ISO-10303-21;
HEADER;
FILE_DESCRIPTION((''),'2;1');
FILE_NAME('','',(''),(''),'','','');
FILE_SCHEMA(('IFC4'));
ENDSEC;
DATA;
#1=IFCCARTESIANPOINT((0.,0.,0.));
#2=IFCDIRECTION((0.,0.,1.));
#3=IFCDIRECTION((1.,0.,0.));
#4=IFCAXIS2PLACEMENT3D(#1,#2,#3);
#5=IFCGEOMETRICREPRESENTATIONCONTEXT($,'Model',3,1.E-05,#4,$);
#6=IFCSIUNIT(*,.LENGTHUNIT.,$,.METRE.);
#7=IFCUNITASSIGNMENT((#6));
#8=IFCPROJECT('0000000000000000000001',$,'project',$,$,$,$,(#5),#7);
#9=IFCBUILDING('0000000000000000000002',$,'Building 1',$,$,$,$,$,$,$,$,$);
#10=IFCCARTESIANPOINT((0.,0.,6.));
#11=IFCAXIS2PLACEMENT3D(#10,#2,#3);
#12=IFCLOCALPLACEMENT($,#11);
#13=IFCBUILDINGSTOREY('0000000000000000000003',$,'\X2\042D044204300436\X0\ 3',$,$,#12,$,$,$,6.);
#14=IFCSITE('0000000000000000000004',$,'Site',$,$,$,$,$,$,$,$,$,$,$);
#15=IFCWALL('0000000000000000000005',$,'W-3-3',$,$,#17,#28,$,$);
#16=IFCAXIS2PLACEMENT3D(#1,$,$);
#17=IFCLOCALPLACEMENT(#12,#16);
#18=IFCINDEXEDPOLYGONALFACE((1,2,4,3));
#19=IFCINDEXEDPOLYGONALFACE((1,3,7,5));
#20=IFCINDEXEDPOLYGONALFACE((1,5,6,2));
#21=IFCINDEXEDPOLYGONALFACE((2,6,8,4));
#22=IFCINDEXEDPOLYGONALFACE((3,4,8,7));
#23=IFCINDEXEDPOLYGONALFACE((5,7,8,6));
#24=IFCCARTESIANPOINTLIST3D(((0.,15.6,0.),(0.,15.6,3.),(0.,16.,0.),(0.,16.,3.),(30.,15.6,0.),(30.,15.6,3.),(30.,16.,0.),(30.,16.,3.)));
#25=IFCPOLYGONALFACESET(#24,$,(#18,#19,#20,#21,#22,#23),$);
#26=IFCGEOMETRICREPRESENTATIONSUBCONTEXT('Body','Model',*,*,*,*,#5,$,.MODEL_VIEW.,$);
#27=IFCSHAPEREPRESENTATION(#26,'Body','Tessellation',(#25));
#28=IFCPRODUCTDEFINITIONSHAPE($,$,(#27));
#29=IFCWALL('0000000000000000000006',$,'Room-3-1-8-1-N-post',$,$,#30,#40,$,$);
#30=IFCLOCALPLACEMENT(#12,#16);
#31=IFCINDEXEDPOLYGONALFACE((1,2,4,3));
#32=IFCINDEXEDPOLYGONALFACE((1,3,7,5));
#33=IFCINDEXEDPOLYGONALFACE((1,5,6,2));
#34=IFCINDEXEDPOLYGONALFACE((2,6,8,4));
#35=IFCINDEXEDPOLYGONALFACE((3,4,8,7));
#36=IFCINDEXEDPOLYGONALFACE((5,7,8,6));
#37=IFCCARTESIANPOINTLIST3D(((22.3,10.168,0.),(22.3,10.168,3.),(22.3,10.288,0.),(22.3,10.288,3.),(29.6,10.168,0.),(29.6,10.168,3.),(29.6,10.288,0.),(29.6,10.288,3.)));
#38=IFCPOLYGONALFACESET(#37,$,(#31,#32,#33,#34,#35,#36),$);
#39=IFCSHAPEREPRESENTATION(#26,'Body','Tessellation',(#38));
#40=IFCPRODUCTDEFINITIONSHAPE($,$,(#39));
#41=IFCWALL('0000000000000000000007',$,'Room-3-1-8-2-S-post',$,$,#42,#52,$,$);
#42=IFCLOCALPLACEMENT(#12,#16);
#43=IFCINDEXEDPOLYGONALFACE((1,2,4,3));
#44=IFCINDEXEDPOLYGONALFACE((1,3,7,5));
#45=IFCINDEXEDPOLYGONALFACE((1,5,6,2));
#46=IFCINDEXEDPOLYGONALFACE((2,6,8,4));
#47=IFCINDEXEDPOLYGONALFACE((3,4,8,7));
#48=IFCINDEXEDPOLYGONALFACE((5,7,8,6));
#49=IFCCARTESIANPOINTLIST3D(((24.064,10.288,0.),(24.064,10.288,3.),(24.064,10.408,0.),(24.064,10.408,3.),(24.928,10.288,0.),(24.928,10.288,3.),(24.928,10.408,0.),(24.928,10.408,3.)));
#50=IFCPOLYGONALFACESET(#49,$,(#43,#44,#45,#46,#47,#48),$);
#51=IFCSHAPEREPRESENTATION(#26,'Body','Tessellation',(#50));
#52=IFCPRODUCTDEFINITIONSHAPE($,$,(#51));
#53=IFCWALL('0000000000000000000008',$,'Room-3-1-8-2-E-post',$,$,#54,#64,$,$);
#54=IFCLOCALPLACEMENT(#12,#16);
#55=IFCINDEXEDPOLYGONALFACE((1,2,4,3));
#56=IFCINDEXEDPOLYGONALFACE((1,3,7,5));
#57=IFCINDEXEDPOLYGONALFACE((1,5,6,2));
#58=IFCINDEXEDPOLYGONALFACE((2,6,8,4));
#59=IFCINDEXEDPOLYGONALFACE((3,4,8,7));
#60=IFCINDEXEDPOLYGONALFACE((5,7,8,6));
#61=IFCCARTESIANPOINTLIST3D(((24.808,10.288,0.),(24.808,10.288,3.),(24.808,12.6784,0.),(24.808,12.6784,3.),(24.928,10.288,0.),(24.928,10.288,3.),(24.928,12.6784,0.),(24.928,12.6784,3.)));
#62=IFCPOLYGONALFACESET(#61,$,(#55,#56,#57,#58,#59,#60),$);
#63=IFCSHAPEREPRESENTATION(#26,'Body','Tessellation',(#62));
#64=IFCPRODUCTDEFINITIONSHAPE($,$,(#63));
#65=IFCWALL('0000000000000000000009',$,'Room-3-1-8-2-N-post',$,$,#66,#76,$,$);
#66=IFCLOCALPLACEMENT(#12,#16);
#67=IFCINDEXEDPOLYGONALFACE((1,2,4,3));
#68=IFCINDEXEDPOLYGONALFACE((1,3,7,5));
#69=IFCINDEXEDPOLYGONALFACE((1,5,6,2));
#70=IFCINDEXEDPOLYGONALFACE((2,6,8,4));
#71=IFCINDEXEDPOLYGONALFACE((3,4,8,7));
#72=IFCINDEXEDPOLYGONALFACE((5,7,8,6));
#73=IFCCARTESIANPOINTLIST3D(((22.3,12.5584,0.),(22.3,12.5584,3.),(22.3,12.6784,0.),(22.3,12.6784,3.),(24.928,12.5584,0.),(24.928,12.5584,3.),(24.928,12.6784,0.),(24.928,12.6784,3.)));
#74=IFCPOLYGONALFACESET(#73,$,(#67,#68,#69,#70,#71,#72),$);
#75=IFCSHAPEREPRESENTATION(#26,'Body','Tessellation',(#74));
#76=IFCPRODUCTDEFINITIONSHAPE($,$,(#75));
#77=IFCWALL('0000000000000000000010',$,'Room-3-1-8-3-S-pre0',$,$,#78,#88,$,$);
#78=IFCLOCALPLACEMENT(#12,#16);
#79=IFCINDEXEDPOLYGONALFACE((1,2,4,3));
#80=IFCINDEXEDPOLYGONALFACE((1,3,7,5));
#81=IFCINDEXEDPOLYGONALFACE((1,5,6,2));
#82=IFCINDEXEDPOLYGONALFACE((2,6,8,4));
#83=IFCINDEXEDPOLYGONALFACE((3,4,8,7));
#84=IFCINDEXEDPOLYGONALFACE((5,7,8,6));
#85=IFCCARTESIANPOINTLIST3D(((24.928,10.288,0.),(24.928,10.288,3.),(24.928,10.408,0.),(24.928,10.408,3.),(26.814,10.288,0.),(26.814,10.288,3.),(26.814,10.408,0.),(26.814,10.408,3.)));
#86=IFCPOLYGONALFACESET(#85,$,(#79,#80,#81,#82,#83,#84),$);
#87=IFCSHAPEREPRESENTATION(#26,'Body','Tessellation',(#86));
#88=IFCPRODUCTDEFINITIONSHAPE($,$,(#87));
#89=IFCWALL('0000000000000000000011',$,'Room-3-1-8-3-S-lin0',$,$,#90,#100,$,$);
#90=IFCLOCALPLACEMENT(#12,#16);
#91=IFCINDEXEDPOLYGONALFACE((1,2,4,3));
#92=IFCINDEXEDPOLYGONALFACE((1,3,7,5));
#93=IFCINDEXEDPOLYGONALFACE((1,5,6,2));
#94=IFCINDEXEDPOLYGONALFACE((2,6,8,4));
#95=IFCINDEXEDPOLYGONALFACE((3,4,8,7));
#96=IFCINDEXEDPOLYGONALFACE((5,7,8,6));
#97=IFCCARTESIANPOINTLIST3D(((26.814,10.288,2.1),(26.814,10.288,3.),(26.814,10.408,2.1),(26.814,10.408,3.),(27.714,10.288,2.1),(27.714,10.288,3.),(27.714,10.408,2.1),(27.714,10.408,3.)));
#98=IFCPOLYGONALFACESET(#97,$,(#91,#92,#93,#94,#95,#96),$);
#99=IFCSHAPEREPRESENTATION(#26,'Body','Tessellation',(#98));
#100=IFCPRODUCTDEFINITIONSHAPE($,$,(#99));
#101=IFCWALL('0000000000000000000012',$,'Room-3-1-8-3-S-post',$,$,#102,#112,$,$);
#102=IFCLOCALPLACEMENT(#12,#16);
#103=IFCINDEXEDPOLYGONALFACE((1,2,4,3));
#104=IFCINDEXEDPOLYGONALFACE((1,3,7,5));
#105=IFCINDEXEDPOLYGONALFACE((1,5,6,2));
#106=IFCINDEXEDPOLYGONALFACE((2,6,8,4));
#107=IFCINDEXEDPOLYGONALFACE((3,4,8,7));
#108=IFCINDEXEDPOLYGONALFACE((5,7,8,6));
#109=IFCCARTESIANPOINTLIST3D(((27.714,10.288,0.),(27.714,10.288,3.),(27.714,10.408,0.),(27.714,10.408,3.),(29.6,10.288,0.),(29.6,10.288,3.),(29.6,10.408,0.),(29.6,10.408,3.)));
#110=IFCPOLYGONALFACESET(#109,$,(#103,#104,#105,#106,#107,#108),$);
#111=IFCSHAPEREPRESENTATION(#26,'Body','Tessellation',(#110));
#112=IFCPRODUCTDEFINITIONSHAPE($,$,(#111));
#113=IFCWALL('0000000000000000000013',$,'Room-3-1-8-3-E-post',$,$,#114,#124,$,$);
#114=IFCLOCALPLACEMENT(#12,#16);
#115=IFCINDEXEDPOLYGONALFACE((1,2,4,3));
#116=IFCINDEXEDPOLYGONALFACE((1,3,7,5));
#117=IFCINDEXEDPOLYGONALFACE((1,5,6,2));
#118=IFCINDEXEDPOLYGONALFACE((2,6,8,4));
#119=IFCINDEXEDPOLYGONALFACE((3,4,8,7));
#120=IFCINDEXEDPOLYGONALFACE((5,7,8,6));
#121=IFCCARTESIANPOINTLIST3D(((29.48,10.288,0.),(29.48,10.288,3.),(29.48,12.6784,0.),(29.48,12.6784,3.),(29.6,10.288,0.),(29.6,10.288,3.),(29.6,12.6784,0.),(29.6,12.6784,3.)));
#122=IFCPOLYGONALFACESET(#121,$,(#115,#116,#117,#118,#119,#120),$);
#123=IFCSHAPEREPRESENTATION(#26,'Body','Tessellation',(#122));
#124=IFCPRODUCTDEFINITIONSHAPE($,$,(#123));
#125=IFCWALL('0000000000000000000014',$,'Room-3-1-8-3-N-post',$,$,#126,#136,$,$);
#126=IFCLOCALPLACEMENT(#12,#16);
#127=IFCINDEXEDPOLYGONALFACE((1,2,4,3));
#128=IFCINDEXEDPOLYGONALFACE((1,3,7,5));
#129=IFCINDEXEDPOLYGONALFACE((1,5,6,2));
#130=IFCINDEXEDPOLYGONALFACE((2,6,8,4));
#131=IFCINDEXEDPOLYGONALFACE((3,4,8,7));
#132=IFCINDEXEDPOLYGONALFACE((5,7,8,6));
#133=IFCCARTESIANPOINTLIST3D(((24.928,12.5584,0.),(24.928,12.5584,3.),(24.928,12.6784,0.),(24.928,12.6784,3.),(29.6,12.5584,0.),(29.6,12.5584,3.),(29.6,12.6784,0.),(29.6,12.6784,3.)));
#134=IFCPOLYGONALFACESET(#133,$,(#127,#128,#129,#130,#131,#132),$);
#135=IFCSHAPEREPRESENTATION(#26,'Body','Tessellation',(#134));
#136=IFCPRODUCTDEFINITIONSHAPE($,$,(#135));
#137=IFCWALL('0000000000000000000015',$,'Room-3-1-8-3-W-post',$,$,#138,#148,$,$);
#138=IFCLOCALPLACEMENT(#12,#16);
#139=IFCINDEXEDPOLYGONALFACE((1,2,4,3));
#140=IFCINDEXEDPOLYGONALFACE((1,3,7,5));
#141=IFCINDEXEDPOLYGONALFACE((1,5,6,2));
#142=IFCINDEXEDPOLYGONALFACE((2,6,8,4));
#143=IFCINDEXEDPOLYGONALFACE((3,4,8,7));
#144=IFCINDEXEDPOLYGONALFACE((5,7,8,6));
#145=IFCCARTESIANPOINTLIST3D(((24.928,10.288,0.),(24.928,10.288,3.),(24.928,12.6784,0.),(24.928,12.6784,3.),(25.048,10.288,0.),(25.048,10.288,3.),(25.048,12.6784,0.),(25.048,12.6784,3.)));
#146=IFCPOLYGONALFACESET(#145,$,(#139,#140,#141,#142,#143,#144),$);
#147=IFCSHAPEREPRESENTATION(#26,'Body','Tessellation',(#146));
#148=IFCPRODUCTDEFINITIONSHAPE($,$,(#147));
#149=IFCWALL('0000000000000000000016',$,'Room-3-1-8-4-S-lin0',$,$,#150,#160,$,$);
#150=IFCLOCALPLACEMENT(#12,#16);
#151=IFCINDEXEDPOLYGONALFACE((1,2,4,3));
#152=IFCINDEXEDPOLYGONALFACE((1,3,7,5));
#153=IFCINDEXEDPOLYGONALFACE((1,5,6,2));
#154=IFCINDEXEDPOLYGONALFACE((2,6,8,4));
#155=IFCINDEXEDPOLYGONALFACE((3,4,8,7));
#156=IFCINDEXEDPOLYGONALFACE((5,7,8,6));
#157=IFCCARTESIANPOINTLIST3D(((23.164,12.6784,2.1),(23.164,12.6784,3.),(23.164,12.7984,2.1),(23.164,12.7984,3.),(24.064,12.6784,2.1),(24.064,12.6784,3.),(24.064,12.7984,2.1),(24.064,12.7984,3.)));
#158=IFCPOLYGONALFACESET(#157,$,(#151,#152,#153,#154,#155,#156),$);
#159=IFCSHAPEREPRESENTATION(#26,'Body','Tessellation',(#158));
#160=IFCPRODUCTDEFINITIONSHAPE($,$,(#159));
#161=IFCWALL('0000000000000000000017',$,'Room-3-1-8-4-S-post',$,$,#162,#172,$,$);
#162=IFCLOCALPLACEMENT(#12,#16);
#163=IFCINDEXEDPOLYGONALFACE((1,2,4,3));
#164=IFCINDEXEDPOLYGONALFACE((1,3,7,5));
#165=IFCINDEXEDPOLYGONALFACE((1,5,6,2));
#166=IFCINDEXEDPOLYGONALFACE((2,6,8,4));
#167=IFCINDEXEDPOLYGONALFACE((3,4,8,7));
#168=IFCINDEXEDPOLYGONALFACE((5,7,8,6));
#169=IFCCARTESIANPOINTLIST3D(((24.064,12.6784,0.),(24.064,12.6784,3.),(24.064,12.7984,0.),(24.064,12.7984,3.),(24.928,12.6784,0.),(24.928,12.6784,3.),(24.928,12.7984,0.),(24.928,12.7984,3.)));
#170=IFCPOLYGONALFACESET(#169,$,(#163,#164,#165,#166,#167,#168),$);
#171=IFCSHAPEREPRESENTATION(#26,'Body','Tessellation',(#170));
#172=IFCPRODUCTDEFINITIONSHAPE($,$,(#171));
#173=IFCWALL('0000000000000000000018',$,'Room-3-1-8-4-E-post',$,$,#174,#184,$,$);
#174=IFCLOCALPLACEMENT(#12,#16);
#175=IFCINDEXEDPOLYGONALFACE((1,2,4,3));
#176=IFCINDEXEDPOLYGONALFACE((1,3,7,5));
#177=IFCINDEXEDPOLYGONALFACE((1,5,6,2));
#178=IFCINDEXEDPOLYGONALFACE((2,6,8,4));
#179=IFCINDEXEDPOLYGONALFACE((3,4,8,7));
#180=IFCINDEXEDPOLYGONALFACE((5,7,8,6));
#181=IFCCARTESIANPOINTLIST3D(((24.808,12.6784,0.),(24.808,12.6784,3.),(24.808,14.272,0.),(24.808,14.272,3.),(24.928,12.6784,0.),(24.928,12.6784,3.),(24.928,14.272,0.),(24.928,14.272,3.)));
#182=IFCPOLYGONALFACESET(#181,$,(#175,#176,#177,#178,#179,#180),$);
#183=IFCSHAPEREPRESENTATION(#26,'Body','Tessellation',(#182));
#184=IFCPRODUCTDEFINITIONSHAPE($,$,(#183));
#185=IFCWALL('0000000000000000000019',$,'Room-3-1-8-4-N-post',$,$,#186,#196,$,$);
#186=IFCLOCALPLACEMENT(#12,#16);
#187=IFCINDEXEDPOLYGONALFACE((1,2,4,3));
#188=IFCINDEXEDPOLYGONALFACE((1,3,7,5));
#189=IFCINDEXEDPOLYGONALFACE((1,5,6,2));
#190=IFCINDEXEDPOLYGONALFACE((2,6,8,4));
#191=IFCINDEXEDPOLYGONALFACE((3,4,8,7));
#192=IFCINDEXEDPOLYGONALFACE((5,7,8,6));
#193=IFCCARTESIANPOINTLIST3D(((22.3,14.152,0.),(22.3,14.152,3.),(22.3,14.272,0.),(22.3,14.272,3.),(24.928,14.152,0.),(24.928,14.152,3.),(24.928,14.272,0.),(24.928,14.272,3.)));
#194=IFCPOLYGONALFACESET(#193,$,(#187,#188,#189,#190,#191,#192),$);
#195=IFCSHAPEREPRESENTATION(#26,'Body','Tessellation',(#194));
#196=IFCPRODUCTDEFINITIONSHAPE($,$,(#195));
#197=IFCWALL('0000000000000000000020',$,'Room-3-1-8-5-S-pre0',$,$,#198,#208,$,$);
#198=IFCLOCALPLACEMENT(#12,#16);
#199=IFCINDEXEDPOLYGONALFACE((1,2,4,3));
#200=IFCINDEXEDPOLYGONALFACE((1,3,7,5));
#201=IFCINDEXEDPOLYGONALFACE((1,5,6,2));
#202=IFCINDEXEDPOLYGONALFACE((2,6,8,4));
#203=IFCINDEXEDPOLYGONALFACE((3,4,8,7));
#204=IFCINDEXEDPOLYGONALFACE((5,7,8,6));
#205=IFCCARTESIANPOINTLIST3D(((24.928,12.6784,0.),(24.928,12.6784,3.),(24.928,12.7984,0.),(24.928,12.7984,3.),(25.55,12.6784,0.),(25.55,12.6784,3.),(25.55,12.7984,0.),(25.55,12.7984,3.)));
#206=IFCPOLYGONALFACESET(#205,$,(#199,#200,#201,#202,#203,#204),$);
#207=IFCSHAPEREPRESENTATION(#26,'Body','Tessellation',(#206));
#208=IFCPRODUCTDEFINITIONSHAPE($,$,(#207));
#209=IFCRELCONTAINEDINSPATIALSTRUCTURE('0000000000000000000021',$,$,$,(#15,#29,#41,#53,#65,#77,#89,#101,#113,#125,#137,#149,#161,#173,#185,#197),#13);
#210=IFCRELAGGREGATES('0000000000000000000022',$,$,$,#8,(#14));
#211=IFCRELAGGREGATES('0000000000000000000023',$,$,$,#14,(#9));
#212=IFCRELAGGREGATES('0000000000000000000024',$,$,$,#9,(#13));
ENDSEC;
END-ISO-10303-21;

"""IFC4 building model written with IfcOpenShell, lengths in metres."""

from ifc_helpers import new_model, si_unit, frame, origin_with_axes, place, context, subcontext, project, spatial, indexed_curve, outline, extrude, element, save


model = new_model("IFC4")

# Units and contexts
model_context = context("Model", 3, precision=1e-05, world=origin_with_axes())
body_context = subcontext(model_context, "Body", "Model", "MODEL_VIEW")
ifc_project = project(units=[si_unit("LENGTHUNIT", "METRE")], contexts=[model_context])

# Site, building, storey
site = spatial("IfcSite", under=ifc_project, Name="Site")
building = spatial("IfcBuilding", under=site, Name="Building 1")
storey_placement = place(None, frame((0.0, 0.0, 6.0), z_axis=(0.0, 0.0, 1.0), x_axis=(1.0, 0.0, 0.0)))
storey = spatial("IfcBuildingStorey", under=building, at=storey_placement, Name="Этаж 3", Elevation=6.0)

# Walls
wall_1_placement = place(storey_placement, frame((30.0, 16.0, 0.0), z_axis=(0.0, 0.0, 1.0), x_axis=(-1.0, 0.0, 0.0)))
element("IfcWall", 1, at=wall_1_placement, inside=storey, Name="W-3-3", context=body_context, shape_type="SweptSolid", body=[
    extrude(outline(indexed_curve([(0.0, 0.0), (0.0, 0.4), (30.0, 0.4), (30.0, 0.0), (0.0, 0.0)], self_intersect=False)), origin_with_axes(), (0.0, 0.0, 1.0), 3.0),
])
wall_2_placement = place(storey_placement, frame((29.6, 10.288, 0.0), z_axis=(0.0, 0.0, 1.0), x_axis=(-1.0, 0.0, 0.0)))
element("IfcWall", 2, at=wall_2_placement, inside=storey, Name="Room-3-1-8-1-N-post", context=body_context, shape_type="SweptSolid", body=[
    extrude(outline(indexed_curve([(0.0, 0.0), (0.0, 0.12), (7.3, 0.12), (7.3, 0.0), (0.0, 0.0)], self_intersect=False)), origin_with_axes(), (0.0, 0.0, 1.0), 3.0),
])
wall_3_placement = place(storey_placement, frame((24.064, 10.288, 0.0), z_axis=(0.0, 0.0, 1.0), x_axis=(1.0, 0.0, 0.0)))
element("IfcWall", 3, at=wall_3_placement, inside=storey, Name="Room-3-1-8-2-S-post", context=body_context, shape_type="SweptSolid", body=[
    extrude(outline(indexed_curve([(0.0, 0.0), (0.0, 0.12), (0.864, 0.12), (0.864, 0.0), (0.0, 0.0)], self_intersect=False)), origin_with_axes(), (0.0, 0.0, 1.0), 3.0),
])
wall_4_placement = place(storey_placement, frame((24.928, 10.288, 0.0), z_axis=(0.0, 0.0, 1.0), x_axis=(0.0, 1.0, 0.0)))
element("IfcWall", 4, at=wall_4_placement, inside=storey, Name="Room-3-1-8-2-E-post", context=body_context, shape_type="SweptSolid", body=[
    extrude(outline(indexed_curve([(0.0, 0.0), (0.0, 0.12), (2.3904, 0.12), (2.3904, 0.0), (0.0, 0.0)], self_intersect=False)), origin_with_axes(), (0.0, 0.0, 1.0), 3.0),
])
wall_5_placement = place(storey_placement, frame((24.928, 12.6784, 0.0), z_axis=(0.0, 0.0, 1.0), x_axis=(-1.0, 0.0, 0.0)))
element("IfcWall", 5, at=wall_5_placement, inside=storey, Name="Room-3-1-8-2-N-post", context=body_context, shape_type="SweptSolid", body=[
    extrude(outline(indexed_curve([(0.0, 0.0), (0.0, 0.12), (2.628, 0.12), (2.628, 0.0), (0.0, 0.0)], self_intersect=False)), origin_with_axes(), (0.0, 0.0, 1.0), 3.0),
])
wall_6_placement = place(storey_placement, frame((24.928, 10.288, 0.0), z_axis=(0.0, 0.0, 1.0), x_axis=(1.0, 0.0, 0.0)))
element("IfcWall", 6, at=wall_6_placement, inside=storey, Name="Room-3-1-8-3-S-pre0", context=body_context, shape_type="SweptSolid", body=[
    extrude(outline(indexed_curve([(0.0, 0.0), (0.0, 0.12), (1.886, 0.12), (1.886, 0.0), (0.0, 0.0)], self_intersect=False)), origin_with_axes(), (0.0, 0.0, 1.0), 3.0),
])
wall_7_placement = place(storey_placement, frame((26.814, 10.288, 2.1), z_axis=(0.0, 0.0, 1.0), x_axis=(1.0, 0.0, 0.0)))
element("IfcWall", 7, at=wall_7_placement, inside=storey, Name="Room-3-1-8-3-S-lin0", context=body_context, shape_type="SweptSolid", body=[
    extrude(outline(indexed_curve([(0.0, 0.0), (0.0, 0.12), (0.9, 0.12), (0.9, 0.0), (0.0, 0.0)], self_intersect=False)), origin_with_axes(), (0.0, 0.0, 1.0), 0.9),
])
wall_8_placement = place(storey_placement, frame((27.714, 10.288, 0.0), z_axis=(0.0, 0.0, 1.0), x_axis=(1.0, 0.0, 0.0)))
element("IfcWall", 8, at=wall_8_placement, inside=storey, Name="Room-3-1-8-3-S-post", context=body_context, shape_type="SweptSolid", body=[
    extrude(outline(indexed_curve([(0.0, 0.0), (0.0, 0.12), (1.886, 0.12), (1.886, 0.0), (0.0, 0.0)], self_intersect=False)), origin_with_axes(), (0.0, 0.0, 1.0), 3.0),
])
wall_9_placement = place(storey_placement, frame((29.6, 10.288, 0.0), z_axis=(0.0, 0.0, 1.0), x_axis=(0.0, 1.0, 0.0)))
element("IfcWall", 9, at=wall_9_placement, inside=storey, Name="Room-3-1-8-3-E-post", context=body_context, shape_type="SweptSolid", body=[
    extrude(outline(indexed_curve([(0.0, 0.0), (0.0, 0.12), (2.3904, 0.12), (2.3904, 0.0), (0.0, 0.0)], self_intersect=False)), origin_with_axes(), (0.0, 0.0, 1.0), 3.0),
])
wall_10_placement = place(storey_placement, frame((29.6, 12.6784, 0.0), z_axis=(0.0, 0.0, 1.0), x_axis=(-1.0, 0.0, 0.0)))
element("IfcWall", 10, at=wall_10_placement, inside=storey, Name="Room-3-1-8-3-N-post", context=body_context, shape_type="SweptSolid", body=[
    extrude(outline(indexed_curve([(0.0, 0.0), (0.0, 0.12), (4.672, 0.12), (4.672, 0.0), (0.0, 0.0)], self_intersect=False)), origin_with_axes(), (0.0, 0.0, 1.0), 3.0),
])
wall_11_placement = place(storey_placement, frame((24.928, 12.6784, 0.0), z_axis=(0.0, 0.0, 1.0), x_axis=(0.0, -1.0, 0.0)))
element("IfcWall", 11, at=wall_11_placement, inside=storey, Name="Room-3-1-8-3-W-post", context=body_context, shape_type="SweptSolid", body=[
    extrude(outline(indexed_curve([(0.0, 0.0), (0.0, 0.12), (2.3904, 0.12), (2.3904, 0.0), (0.0, 0.0)], self_intersect=False)), origin_with_axes(), (0.0, 0.0, 1.0), 3.0),
])
wall_12_placement = place(storey_placement, frame((23.164, 12.6784, 2.1), z_axis=(0.0, 0.0, 1.0), x_axis=(1.0, 0.0, 0.0)))
element("IfcWall", 12, at=wall_12_placement, inside=storey, Name="Room-3-1-8-4-S-lin0", context=body_context, shape_type="SweptSolid", body=[
    extrude(outline(indexed_curve([(0.0, 0.0), (0.0, 0.12), (0.9, 0.12), (0.9, 0.0), (0.0, 0.0)], self_intersect=False)), origin_with_axes(), (0.0, 0.0, 1.0), 0.9),
])
wall_13_placement = place(storey_placement, frame((24.064, 12.6784, 0.0), z_axis=(0.0, 0.0, 1.0), x_axis=(1.0, 0.0, 0.0)))
element("IfcWall", 13, at=wall_13_placement, inside=storey, Name="Room-3-1-8-4-S-post", context=body_context, shape_type="SweptSolid", body=[
    extrude(outline(indexed_curve([(0.0, 0.0), (0.0, 0.12), (0.864, 0.12), (0.864, 0.0), (0.0, 0.0)], self_intersect=False)), origin_with_axes(), (0.0, 0.0, 1.0), 3.0),
])
wall_14_placement = place(storey_placement, frame((24.928, 12.6784, 0.0), z_axis=(0.0, 0.0, 1.0), x_axis=(0.0, 1.0, 0.0)))
element("IfcWall", 14, at=wall_14_placement, inside=storey, Name="Room-3-1-8-4-E-post", context=body_context, shape_type="SweptSolid", body=[
    extrude(outline(indexed_curve([(0.0, 0.0), (0.0, 0.12), (1.5936, 0.12), (1.5936, 0.0), (0.0, 0.0)], self_intersect=False)), origin_with_axes(), (0.0, 0.0, 1.0), 3.0),
])
wall_15_placement = place(storey_placement, frame((24.928, 14.272, 0.0), z_axis=(0.0, 0.0, 1.0), x_axis=(-1.0, 0.0, 0.0)))
element("IfcWall", 15, at=wall_15_placement, inside=storey, Name="Room-3-1-8-4-N-post", context=body_context, shape_type="SweptSolid", body=[
    extrude(outline(indexed_curve([(0.0, 0.0), (0.0, 0.12), (2.628, 0.12), (2.628, 0.0), (0.0, 0.0)], self_intersect=False)), origin_with_axes(), (0.0, 0.0, 1.0), 3.0),
])
wall_16_placement = place(storey_placement, frame((24.928, 12.6784, 0.0), z_axis=(0.0, 0.0, 1.0), x_axis=(1.0, 0.0, 0.0)))
element("IfcWall", 16, at=wall_16_placement, inside=storey, Name="Room-3-1-8-5-S-pre0", context=body_context, shape_type="SweptSolid", body=[
    extrude(outline(indexed_curve([(0.0, 0.0), (0.0, 0.12), (0.622, 0.12), (0.622, 0.0), (0.0, 0.0)], self_intersect=False)), origin_with_axes(), (0.0, 0.0, 1.0), 3.0),
])

save(model, "model.ifc")
